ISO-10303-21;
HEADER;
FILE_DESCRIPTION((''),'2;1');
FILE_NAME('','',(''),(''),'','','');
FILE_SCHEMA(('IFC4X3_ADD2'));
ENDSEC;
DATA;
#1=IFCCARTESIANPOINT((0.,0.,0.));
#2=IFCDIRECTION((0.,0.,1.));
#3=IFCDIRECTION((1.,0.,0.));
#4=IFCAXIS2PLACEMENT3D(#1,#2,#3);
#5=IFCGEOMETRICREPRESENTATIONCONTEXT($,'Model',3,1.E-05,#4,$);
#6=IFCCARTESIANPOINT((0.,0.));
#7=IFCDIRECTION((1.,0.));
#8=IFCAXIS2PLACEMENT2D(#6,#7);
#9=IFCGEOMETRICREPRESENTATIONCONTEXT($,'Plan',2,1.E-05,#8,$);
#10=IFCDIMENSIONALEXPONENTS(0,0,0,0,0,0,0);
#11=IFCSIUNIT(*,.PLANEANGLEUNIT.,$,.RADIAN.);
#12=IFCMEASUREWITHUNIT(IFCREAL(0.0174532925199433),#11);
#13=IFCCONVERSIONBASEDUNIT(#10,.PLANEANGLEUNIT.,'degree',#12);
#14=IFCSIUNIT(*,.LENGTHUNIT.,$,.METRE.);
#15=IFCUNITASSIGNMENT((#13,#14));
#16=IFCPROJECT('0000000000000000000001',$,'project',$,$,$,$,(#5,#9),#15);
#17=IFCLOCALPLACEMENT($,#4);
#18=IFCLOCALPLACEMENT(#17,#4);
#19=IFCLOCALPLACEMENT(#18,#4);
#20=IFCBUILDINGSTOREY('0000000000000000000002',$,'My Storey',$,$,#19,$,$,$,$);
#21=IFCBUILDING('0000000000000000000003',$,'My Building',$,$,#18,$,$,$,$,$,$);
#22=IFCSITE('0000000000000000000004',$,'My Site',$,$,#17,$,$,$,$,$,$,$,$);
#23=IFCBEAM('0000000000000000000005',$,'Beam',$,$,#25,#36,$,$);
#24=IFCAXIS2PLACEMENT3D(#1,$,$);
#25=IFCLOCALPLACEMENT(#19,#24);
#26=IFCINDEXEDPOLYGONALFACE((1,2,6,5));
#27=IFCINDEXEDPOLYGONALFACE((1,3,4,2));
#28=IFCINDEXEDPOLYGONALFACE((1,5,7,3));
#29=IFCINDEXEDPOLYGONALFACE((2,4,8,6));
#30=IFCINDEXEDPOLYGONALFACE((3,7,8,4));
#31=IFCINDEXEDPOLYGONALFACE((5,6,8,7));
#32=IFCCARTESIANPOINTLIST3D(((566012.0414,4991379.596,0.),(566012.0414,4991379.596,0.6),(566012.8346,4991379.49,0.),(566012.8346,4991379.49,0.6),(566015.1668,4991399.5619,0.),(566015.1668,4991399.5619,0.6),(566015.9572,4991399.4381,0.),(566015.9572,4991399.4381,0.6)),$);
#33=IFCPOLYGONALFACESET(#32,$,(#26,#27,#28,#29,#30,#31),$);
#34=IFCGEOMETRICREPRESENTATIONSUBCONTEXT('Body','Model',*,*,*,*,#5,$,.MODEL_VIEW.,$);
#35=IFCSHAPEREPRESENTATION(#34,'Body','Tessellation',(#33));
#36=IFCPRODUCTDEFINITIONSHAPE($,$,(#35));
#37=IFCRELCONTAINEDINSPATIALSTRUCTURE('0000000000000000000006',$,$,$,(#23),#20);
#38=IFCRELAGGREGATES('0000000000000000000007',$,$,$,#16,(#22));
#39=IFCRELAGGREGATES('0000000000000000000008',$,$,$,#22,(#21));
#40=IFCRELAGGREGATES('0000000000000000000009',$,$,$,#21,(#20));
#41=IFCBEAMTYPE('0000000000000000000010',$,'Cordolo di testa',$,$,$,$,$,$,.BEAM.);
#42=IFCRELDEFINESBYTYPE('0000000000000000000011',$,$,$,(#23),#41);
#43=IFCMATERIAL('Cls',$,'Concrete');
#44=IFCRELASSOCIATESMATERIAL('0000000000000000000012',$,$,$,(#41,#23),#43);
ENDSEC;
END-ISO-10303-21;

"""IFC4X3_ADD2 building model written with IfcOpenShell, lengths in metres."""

from ifc_helpers import new_model, entity, si_unit, converted_unit, frame, origin_with_axes, origin_2d_with_axis, place, context, subcontext, project, spatial, rectangle, extrude, clip, halfspace, material, material_profile, profile_set, profile_usage, type_object, element, save


model = new_model("IFC4X3_ADD2")

# Units and contexts
model_context = context("Model", 3, precision=1e-05, world=origin_with_axes())
plan_context = context("Plan", 2, precision=1e-05, world=origin_2d_with_axis())
body_context = subcontext(model_context, "Body", "Model", "MODEL_VIEW")
ifc_project = project(units=[converted_unit("PLANEANGLEUNIT", "degree", entity("IfcReal", 0.0174532925199433), si_unit("PLANEANGLEUNIT", "RADIAN"), dimensions=[0, 0, 0, 0, 0, 0, 0]), si_unit("LENGTHUNIT", "METRE")], contexts=[model_context, plan_context])

# Site, building, storey
site_placement = place(None, origin_with_axes())
site = spatial("IfcSite", under=ifc_project, at=site_placement, Name="My Site")
building_placement = place(site_placement, origin_with_axes())
building = spatial("IfcBuilding", under=site, at=building_placement, Name="My Building")
storey_placement = place(building_placement, origin_with_axes())
storey = spatial("IfcBuildingStorey", under=building, at=storey_placement, Name="My Storey")

# Beam
ifc_material = material(Name="Cls", Category="Concrete")
ifc_material_profile = material_profile(ifc_material, rectangle(XDim=0.8, YDim=0.6))
ifc_profile_set = profile_set([ifc_material_profile])
ifc_profile_usage_1 = profile_usage(ifc_profile_set, cardinal=2)
beam_type = type_object("IfcBeamType", Name="Cordolo di testa", PredefinedType="BEAM", material=ifc_profile_set)
beam_1_placement = place(storey_placement, frame((566015.562, 4991399.5, 0.0), z_axis=(-0.154654, -0.987969, 0.0), x_axis=(0.987969, -0.154654, 0.0)))
element("IfcBeam", 1, at=beam_1_placement, inside=storey, type_object=beam_type, material=ifc_profile_usage_1, Name="Beam", context=body_context, shape_type="Clipping", body=[
    clip(extrude(rectangle(XDim=0.8, YDim=0.6), frame((0.0, 0.3, 0.0), z_axis=(0.0, 0.0, 1.0), x_axis=(1.0, 0.0, 0.0)), (0.0, 0.0, 1.0), 26.259), halfspace(frame((-0.25, 0.0, 20.2057), z_axis=(0.022492, 0.0, 0.999747), x_axis=(-0.000018, -1.0, 0.0)), False)),
])

save(model, "model.ifc")
